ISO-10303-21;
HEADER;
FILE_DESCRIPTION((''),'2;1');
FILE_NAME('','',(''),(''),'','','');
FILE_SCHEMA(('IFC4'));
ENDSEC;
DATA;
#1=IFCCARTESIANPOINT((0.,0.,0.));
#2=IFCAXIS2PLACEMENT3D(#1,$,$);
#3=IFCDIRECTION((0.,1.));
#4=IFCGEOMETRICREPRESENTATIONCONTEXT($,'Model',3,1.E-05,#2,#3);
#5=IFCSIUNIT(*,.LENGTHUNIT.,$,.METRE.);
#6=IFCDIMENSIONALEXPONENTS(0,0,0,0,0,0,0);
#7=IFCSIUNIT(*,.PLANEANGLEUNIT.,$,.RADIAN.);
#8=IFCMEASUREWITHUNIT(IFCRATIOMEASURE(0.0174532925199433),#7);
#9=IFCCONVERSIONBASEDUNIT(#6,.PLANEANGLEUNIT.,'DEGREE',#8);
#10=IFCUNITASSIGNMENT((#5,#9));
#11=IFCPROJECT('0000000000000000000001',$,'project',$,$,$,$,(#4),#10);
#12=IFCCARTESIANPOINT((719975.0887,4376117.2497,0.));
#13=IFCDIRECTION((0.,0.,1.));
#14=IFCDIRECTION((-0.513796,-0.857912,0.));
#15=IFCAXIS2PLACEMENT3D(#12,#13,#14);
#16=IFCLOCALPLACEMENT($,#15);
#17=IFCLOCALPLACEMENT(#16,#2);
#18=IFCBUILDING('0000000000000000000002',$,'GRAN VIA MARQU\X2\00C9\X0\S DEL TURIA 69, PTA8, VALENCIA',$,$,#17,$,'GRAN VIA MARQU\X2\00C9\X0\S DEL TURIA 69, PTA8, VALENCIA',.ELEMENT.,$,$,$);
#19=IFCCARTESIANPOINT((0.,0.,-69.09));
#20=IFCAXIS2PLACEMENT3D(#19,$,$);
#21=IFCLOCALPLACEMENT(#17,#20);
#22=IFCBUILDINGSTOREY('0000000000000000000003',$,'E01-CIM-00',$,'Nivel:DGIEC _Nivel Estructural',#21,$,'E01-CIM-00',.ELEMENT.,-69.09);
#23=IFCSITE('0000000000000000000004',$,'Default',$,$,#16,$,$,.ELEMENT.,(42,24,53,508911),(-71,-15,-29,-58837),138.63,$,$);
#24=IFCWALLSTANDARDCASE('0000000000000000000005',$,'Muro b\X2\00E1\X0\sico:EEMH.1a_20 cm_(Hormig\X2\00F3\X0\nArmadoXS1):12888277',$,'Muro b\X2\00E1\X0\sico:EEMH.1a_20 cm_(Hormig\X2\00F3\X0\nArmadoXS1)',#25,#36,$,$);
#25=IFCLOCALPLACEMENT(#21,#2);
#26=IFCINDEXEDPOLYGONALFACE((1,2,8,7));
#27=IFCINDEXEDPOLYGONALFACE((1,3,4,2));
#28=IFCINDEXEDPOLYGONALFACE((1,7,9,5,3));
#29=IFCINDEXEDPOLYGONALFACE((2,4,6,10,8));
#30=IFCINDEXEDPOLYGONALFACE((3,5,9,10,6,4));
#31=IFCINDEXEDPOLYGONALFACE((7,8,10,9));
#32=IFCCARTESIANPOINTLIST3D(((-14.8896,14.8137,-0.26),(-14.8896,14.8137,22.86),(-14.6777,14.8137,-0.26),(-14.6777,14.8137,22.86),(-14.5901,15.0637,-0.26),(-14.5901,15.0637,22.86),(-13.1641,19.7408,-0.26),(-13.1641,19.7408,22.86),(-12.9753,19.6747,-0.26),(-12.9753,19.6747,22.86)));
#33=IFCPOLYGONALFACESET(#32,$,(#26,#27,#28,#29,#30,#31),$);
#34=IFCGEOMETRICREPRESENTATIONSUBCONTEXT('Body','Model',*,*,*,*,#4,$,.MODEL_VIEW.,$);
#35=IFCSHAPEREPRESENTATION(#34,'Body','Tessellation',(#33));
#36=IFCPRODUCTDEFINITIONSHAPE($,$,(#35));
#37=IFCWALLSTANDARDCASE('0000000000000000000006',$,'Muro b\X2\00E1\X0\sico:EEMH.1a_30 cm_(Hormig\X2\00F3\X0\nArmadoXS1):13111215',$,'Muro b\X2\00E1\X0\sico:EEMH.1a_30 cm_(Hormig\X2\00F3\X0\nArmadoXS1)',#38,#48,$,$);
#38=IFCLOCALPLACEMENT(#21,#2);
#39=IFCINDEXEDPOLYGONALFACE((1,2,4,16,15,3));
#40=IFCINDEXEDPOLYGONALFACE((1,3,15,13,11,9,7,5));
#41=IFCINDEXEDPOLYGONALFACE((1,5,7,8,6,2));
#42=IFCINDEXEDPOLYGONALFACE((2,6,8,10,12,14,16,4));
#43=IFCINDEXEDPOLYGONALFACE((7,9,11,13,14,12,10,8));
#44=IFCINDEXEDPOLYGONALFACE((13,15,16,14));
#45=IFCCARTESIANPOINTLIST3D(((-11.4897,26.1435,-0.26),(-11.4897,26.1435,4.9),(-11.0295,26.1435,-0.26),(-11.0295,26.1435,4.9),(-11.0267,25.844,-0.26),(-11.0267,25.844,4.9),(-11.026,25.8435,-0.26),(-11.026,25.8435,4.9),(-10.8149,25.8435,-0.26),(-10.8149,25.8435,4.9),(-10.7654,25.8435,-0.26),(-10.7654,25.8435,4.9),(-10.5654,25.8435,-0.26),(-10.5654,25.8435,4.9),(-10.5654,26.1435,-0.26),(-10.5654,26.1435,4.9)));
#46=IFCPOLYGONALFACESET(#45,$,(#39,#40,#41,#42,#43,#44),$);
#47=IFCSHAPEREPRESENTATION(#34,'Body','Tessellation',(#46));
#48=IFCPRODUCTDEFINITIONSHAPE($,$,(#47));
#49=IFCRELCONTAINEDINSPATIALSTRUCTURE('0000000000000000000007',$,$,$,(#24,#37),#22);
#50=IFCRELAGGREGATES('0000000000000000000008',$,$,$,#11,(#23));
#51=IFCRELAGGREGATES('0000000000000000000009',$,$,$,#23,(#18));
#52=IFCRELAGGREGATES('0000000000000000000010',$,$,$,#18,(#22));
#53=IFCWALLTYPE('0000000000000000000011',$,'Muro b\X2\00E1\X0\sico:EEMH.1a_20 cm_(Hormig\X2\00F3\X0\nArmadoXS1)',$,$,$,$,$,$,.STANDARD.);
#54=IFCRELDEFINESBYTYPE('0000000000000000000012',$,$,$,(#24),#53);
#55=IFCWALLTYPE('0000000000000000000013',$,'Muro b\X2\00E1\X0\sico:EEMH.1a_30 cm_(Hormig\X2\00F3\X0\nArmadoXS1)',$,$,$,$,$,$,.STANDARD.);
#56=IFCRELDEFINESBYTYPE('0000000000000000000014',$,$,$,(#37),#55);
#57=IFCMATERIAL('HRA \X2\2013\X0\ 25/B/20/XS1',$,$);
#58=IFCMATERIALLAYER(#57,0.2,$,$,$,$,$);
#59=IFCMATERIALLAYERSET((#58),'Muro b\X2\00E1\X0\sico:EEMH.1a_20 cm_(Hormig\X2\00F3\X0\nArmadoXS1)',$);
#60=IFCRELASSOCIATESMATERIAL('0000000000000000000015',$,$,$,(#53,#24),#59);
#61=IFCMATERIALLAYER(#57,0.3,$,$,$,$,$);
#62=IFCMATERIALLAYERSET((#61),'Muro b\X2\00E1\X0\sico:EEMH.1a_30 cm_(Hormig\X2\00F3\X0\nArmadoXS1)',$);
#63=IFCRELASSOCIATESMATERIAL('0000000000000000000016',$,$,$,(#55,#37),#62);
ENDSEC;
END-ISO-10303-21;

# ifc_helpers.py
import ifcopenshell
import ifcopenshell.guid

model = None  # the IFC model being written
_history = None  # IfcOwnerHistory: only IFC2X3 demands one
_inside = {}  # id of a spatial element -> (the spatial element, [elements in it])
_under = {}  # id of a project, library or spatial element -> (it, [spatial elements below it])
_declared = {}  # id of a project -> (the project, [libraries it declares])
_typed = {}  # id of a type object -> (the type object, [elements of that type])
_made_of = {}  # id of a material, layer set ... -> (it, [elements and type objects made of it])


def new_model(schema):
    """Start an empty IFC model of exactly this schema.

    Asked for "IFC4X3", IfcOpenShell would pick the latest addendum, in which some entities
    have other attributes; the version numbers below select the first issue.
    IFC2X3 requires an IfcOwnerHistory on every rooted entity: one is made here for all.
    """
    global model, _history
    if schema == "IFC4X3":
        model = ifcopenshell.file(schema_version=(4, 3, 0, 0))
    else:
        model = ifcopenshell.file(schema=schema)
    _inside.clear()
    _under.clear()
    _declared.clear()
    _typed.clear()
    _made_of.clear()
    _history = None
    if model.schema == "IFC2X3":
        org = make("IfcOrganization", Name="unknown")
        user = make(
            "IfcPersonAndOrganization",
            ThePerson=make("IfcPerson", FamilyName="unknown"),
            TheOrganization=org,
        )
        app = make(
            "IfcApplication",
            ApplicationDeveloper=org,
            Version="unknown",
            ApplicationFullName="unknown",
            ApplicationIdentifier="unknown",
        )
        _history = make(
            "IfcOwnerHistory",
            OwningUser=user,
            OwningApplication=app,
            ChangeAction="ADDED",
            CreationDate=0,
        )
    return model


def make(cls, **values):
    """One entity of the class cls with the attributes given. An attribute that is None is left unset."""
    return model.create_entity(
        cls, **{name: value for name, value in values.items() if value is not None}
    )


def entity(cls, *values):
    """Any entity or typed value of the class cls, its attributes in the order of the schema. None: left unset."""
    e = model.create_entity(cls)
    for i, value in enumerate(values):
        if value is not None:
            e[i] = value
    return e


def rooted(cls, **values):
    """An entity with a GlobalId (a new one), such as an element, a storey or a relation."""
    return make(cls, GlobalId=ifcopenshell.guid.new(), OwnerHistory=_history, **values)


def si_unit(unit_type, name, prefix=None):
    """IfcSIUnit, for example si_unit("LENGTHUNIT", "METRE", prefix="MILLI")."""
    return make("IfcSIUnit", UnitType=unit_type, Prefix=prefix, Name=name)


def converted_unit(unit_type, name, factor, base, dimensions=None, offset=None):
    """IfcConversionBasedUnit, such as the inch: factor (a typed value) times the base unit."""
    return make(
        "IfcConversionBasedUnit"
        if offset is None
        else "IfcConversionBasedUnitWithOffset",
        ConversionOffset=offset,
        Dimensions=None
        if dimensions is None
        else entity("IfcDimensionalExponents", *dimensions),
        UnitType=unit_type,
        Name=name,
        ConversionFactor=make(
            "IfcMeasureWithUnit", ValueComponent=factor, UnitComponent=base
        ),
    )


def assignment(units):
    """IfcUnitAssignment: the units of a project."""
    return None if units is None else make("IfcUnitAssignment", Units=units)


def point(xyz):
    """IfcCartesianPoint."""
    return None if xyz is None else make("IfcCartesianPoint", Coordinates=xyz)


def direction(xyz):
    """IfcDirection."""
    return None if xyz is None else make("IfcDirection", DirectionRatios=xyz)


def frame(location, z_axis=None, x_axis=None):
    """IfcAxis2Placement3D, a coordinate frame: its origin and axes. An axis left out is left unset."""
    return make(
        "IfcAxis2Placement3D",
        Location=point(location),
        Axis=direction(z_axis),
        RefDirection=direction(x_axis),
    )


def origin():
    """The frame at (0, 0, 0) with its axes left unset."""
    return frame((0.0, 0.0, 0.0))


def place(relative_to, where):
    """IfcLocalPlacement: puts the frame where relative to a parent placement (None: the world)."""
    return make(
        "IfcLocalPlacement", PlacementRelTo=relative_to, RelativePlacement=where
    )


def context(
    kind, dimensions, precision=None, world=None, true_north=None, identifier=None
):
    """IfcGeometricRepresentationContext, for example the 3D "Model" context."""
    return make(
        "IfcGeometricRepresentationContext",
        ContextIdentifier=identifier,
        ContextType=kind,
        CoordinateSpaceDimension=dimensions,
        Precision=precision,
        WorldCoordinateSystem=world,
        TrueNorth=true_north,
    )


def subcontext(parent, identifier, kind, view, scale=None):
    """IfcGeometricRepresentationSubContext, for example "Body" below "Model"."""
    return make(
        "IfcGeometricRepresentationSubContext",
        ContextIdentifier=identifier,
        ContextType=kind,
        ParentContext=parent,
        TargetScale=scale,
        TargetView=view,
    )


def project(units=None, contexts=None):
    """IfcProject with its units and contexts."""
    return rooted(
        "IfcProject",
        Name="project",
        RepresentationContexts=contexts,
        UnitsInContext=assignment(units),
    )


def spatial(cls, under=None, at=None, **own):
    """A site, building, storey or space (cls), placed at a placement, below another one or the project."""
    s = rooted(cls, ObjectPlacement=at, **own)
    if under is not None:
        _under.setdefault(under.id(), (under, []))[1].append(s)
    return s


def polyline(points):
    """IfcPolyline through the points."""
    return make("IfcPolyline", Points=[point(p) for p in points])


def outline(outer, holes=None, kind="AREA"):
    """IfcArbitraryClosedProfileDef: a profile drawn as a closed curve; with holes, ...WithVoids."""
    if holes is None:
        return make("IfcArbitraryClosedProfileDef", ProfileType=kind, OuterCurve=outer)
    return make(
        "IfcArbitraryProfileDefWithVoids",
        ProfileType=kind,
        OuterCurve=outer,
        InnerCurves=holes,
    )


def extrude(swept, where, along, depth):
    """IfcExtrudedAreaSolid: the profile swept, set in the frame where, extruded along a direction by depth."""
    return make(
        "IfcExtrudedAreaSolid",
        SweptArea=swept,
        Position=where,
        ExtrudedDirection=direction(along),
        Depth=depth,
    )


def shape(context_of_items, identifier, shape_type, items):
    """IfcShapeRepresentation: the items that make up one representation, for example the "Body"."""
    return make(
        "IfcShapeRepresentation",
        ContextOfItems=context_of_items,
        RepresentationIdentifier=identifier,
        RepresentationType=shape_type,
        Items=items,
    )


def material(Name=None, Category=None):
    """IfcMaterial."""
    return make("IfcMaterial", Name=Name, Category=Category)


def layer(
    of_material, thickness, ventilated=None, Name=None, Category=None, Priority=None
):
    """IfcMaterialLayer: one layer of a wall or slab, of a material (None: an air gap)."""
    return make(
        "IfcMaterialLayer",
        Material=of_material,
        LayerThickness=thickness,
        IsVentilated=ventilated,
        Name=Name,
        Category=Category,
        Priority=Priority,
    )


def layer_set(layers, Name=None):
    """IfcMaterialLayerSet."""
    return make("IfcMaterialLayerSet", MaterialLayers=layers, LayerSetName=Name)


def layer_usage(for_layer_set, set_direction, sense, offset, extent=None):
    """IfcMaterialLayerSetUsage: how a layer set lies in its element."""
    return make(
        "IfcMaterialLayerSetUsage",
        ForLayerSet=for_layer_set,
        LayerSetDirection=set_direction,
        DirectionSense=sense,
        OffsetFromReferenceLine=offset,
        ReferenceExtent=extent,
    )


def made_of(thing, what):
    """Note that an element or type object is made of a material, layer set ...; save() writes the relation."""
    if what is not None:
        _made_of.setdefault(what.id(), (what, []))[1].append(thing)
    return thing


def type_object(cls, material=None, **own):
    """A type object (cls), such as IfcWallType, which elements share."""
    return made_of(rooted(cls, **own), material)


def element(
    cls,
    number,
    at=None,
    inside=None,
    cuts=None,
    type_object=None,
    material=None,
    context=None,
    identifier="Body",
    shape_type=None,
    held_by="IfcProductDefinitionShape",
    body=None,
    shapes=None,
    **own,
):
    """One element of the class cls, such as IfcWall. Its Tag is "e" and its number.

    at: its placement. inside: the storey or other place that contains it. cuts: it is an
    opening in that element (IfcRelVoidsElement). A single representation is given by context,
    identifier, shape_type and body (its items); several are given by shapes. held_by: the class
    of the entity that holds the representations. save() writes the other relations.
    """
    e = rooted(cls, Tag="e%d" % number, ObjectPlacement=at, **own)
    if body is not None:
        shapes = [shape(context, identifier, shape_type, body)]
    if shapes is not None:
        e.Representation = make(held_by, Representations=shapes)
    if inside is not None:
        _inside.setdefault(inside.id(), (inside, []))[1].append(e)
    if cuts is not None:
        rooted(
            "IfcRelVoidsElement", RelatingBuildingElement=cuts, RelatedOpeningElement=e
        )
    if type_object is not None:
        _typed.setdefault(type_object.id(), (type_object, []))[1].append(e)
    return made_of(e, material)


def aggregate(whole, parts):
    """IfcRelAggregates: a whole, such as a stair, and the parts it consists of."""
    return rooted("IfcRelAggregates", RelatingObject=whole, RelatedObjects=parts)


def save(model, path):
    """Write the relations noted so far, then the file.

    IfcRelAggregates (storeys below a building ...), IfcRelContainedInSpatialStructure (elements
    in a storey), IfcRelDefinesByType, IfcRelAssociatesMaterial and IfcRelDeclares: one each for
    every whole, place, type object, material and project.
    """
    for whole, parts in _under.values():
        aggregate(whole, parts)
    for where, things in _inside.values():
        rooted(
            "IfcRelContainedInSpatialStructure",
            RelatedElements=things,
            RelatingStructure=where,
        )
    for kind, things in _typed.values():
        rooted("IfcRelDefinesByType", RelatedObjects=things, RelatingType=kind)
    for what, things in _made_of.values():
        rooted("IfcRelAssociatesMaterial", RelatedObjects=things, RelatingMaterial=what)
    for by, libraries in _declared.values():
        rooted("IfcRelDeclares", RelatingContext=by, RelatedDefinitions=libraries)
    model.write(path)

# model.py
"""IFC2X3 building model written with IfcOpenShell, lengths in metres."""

from ifc_helpers import new_model, entity, si_unit, converted_unit, direction, frame, origin, place, context, subcontext, project, spatial, polyline, outline, extrude, material, layer, layer_set, layer_usage, type_object, element, save


model = new_model("IFC2X3")

# Units and contexts
model_context = context("Model", 3, precision=1e-05, world=origin(), true_north=direction((0.0, 1.0)))
body_context = subcontext(model_context, "Body", "Model", "MODEL_VIEW")
ifc_project = project(units=[si_unit("LENGTHUNIT", "METRE"), converted_unit("PLANEANGLEUNIT", "DEGREE", entity("IfcRatioMeasure", 0.0174532925199433), si_unit("PLANEANGLEUNIT", "RADIAN"), dimensions=[0, 0, 0, 0, 0, 0, 0])], contexts=[model_context])

# Site, building, storey
site_placement = place(None, frame((719975.0887, 4376117.2497, 0.0), z_axis=(0.0, 0.0, 1.0), x_axis=(-0.513796, -0.857912, 0.0)))
site = spatial("IfcSite", under=ifc_project, at=site_placement, Name="Default", CompositionType="ELEMENT", RefLatitude=(42, 24, 53, 508911), RefLongitude=(-71, -15, -29, -58837), RefElevation=138.63)
building_placement = place(site_placement, origin())
building = spatial("IfcBuilding", under=site, at=building_placement, Name="GRAN VIA MARQUÉS DEL TURIA 69, PTA8, VALENCIA", LongName="GRAN VIA MARQUÉS DEL TURIA 69, PTA8, VALENCIA", CompositionType="ELEMENT")
storey_placement = place(building_placement, frame((0.0, 0.0, -69.09)))
storey = spatial("IfcBuildingStorey", under=building, at=storey_placement, Name="E01-CIM-00", ObjectType="Nivel:DGIEC _Nivel Estructural", LongName="E01-CIM-00", CompositionType="ELEMENT", Elevation=-69.09)

# Shared definitions
ifc_material_1 = material(Name="HRA – 25/B/20/XS1")
ifc_layer_1 = layer(ifc_material_1, 0.2)
ifc_layer_set_1 = layer_set([ifc_layer_1], Name="Muro básico:EEMH.1a_20 cm_(HormigónArmadoXS1)")
wall_type_1 = type_object("IfcWallType", Name="Muro básico:EEMH.1a_20 cm_(HormigónArmadoXS1)", PredefinedType="STANDARD", material=ifc_layer_set_1)

# Walls
ifc_layer_usage_1 = layer_usage(ifc_layer_set_1, "AXIS2", "NEGATIVE", 0.1)
wall_1_placement = place(storey_placement, frame((-14.7952, 14.7807, -0.26), z_axis=(0.0, 0.0, 1.0), x_axis=(0.330527, 0.943797, 0.0)))
element("IfcWallStandardCase", 1, at=wall_1_placement, inside=storey, type_object=wall_type_1, material=ifc_layer_usage_1, Name="Muro básico:EEMH.1a_20 cm_(HormigónArmadoXS1):12888277", ObjectType="Muro básico:EEMH.1a_20 cm_(HormigónArmadoXS1)", context=body_context, shape_type="SweptSolid", body=[
    extrude(outline(polyline([(5.2205, -0.1), (5.2205, 0.1), (0.0, 0.1), (0.07, -0.1), (0.3349, -0.1), (5.2205, -0.1)])), origin(), (0.0, 0.0, 1.0), 23.12),
])
ifc_layer_2 = layer(ifc_material_1, 0.3)
ifc_layer_set_2 = layer_set([ifc_layer_2], Name="Muro básico:EEMH.1a_30 cm_(HormigónArmadoXS1)")
ifc_layer_usage_2 = layer_usage(ifc_layer_set_2, "AXIS2", "NEGATIVE", 0.15)
wall_type_2 = type_object("IfcWallType", Name="Muro básico:EEMH.1a_30 cm_(HormigónArmadoXS1)", PredefinedType="STANDARD", material=ifc_layer_set_2)
wall_2_placement = place(storey_placement, frame((-10.5654, 25.9935, -0.26), z_axis=(0.0, 0.0, 1.0), x_axis=(-1.0, 0.0, 0.0)))
element("IfcWallStandardCase", 2, at=wall_2_placement, inside=storey, type_object=wall_type_2, material=ifc_layer_usage_2, Name="Muro básico:EEMH.1a_30 cm_(HormigónArmadoXS1):13111215", ObjectType="Muro básico:EEMH.1a_30 cm_(HormigónArmadoXS1)", context=body_context, shape_type="SweptSolid", body=[
    extrude(outline(polyline([(0.9244, -0.15), (0.4613, 0.1496), (0.4607, 0.15), (0.2496, 0.15), (0.2, 0.15), (0.0, 0.15), (0.0, -0.15), (0.4641, -0.15), (0.9244, -0.15)])), origin(), (0.0, 0.0, 1.0), 5.16),
])

save(model, "model.ifc")
